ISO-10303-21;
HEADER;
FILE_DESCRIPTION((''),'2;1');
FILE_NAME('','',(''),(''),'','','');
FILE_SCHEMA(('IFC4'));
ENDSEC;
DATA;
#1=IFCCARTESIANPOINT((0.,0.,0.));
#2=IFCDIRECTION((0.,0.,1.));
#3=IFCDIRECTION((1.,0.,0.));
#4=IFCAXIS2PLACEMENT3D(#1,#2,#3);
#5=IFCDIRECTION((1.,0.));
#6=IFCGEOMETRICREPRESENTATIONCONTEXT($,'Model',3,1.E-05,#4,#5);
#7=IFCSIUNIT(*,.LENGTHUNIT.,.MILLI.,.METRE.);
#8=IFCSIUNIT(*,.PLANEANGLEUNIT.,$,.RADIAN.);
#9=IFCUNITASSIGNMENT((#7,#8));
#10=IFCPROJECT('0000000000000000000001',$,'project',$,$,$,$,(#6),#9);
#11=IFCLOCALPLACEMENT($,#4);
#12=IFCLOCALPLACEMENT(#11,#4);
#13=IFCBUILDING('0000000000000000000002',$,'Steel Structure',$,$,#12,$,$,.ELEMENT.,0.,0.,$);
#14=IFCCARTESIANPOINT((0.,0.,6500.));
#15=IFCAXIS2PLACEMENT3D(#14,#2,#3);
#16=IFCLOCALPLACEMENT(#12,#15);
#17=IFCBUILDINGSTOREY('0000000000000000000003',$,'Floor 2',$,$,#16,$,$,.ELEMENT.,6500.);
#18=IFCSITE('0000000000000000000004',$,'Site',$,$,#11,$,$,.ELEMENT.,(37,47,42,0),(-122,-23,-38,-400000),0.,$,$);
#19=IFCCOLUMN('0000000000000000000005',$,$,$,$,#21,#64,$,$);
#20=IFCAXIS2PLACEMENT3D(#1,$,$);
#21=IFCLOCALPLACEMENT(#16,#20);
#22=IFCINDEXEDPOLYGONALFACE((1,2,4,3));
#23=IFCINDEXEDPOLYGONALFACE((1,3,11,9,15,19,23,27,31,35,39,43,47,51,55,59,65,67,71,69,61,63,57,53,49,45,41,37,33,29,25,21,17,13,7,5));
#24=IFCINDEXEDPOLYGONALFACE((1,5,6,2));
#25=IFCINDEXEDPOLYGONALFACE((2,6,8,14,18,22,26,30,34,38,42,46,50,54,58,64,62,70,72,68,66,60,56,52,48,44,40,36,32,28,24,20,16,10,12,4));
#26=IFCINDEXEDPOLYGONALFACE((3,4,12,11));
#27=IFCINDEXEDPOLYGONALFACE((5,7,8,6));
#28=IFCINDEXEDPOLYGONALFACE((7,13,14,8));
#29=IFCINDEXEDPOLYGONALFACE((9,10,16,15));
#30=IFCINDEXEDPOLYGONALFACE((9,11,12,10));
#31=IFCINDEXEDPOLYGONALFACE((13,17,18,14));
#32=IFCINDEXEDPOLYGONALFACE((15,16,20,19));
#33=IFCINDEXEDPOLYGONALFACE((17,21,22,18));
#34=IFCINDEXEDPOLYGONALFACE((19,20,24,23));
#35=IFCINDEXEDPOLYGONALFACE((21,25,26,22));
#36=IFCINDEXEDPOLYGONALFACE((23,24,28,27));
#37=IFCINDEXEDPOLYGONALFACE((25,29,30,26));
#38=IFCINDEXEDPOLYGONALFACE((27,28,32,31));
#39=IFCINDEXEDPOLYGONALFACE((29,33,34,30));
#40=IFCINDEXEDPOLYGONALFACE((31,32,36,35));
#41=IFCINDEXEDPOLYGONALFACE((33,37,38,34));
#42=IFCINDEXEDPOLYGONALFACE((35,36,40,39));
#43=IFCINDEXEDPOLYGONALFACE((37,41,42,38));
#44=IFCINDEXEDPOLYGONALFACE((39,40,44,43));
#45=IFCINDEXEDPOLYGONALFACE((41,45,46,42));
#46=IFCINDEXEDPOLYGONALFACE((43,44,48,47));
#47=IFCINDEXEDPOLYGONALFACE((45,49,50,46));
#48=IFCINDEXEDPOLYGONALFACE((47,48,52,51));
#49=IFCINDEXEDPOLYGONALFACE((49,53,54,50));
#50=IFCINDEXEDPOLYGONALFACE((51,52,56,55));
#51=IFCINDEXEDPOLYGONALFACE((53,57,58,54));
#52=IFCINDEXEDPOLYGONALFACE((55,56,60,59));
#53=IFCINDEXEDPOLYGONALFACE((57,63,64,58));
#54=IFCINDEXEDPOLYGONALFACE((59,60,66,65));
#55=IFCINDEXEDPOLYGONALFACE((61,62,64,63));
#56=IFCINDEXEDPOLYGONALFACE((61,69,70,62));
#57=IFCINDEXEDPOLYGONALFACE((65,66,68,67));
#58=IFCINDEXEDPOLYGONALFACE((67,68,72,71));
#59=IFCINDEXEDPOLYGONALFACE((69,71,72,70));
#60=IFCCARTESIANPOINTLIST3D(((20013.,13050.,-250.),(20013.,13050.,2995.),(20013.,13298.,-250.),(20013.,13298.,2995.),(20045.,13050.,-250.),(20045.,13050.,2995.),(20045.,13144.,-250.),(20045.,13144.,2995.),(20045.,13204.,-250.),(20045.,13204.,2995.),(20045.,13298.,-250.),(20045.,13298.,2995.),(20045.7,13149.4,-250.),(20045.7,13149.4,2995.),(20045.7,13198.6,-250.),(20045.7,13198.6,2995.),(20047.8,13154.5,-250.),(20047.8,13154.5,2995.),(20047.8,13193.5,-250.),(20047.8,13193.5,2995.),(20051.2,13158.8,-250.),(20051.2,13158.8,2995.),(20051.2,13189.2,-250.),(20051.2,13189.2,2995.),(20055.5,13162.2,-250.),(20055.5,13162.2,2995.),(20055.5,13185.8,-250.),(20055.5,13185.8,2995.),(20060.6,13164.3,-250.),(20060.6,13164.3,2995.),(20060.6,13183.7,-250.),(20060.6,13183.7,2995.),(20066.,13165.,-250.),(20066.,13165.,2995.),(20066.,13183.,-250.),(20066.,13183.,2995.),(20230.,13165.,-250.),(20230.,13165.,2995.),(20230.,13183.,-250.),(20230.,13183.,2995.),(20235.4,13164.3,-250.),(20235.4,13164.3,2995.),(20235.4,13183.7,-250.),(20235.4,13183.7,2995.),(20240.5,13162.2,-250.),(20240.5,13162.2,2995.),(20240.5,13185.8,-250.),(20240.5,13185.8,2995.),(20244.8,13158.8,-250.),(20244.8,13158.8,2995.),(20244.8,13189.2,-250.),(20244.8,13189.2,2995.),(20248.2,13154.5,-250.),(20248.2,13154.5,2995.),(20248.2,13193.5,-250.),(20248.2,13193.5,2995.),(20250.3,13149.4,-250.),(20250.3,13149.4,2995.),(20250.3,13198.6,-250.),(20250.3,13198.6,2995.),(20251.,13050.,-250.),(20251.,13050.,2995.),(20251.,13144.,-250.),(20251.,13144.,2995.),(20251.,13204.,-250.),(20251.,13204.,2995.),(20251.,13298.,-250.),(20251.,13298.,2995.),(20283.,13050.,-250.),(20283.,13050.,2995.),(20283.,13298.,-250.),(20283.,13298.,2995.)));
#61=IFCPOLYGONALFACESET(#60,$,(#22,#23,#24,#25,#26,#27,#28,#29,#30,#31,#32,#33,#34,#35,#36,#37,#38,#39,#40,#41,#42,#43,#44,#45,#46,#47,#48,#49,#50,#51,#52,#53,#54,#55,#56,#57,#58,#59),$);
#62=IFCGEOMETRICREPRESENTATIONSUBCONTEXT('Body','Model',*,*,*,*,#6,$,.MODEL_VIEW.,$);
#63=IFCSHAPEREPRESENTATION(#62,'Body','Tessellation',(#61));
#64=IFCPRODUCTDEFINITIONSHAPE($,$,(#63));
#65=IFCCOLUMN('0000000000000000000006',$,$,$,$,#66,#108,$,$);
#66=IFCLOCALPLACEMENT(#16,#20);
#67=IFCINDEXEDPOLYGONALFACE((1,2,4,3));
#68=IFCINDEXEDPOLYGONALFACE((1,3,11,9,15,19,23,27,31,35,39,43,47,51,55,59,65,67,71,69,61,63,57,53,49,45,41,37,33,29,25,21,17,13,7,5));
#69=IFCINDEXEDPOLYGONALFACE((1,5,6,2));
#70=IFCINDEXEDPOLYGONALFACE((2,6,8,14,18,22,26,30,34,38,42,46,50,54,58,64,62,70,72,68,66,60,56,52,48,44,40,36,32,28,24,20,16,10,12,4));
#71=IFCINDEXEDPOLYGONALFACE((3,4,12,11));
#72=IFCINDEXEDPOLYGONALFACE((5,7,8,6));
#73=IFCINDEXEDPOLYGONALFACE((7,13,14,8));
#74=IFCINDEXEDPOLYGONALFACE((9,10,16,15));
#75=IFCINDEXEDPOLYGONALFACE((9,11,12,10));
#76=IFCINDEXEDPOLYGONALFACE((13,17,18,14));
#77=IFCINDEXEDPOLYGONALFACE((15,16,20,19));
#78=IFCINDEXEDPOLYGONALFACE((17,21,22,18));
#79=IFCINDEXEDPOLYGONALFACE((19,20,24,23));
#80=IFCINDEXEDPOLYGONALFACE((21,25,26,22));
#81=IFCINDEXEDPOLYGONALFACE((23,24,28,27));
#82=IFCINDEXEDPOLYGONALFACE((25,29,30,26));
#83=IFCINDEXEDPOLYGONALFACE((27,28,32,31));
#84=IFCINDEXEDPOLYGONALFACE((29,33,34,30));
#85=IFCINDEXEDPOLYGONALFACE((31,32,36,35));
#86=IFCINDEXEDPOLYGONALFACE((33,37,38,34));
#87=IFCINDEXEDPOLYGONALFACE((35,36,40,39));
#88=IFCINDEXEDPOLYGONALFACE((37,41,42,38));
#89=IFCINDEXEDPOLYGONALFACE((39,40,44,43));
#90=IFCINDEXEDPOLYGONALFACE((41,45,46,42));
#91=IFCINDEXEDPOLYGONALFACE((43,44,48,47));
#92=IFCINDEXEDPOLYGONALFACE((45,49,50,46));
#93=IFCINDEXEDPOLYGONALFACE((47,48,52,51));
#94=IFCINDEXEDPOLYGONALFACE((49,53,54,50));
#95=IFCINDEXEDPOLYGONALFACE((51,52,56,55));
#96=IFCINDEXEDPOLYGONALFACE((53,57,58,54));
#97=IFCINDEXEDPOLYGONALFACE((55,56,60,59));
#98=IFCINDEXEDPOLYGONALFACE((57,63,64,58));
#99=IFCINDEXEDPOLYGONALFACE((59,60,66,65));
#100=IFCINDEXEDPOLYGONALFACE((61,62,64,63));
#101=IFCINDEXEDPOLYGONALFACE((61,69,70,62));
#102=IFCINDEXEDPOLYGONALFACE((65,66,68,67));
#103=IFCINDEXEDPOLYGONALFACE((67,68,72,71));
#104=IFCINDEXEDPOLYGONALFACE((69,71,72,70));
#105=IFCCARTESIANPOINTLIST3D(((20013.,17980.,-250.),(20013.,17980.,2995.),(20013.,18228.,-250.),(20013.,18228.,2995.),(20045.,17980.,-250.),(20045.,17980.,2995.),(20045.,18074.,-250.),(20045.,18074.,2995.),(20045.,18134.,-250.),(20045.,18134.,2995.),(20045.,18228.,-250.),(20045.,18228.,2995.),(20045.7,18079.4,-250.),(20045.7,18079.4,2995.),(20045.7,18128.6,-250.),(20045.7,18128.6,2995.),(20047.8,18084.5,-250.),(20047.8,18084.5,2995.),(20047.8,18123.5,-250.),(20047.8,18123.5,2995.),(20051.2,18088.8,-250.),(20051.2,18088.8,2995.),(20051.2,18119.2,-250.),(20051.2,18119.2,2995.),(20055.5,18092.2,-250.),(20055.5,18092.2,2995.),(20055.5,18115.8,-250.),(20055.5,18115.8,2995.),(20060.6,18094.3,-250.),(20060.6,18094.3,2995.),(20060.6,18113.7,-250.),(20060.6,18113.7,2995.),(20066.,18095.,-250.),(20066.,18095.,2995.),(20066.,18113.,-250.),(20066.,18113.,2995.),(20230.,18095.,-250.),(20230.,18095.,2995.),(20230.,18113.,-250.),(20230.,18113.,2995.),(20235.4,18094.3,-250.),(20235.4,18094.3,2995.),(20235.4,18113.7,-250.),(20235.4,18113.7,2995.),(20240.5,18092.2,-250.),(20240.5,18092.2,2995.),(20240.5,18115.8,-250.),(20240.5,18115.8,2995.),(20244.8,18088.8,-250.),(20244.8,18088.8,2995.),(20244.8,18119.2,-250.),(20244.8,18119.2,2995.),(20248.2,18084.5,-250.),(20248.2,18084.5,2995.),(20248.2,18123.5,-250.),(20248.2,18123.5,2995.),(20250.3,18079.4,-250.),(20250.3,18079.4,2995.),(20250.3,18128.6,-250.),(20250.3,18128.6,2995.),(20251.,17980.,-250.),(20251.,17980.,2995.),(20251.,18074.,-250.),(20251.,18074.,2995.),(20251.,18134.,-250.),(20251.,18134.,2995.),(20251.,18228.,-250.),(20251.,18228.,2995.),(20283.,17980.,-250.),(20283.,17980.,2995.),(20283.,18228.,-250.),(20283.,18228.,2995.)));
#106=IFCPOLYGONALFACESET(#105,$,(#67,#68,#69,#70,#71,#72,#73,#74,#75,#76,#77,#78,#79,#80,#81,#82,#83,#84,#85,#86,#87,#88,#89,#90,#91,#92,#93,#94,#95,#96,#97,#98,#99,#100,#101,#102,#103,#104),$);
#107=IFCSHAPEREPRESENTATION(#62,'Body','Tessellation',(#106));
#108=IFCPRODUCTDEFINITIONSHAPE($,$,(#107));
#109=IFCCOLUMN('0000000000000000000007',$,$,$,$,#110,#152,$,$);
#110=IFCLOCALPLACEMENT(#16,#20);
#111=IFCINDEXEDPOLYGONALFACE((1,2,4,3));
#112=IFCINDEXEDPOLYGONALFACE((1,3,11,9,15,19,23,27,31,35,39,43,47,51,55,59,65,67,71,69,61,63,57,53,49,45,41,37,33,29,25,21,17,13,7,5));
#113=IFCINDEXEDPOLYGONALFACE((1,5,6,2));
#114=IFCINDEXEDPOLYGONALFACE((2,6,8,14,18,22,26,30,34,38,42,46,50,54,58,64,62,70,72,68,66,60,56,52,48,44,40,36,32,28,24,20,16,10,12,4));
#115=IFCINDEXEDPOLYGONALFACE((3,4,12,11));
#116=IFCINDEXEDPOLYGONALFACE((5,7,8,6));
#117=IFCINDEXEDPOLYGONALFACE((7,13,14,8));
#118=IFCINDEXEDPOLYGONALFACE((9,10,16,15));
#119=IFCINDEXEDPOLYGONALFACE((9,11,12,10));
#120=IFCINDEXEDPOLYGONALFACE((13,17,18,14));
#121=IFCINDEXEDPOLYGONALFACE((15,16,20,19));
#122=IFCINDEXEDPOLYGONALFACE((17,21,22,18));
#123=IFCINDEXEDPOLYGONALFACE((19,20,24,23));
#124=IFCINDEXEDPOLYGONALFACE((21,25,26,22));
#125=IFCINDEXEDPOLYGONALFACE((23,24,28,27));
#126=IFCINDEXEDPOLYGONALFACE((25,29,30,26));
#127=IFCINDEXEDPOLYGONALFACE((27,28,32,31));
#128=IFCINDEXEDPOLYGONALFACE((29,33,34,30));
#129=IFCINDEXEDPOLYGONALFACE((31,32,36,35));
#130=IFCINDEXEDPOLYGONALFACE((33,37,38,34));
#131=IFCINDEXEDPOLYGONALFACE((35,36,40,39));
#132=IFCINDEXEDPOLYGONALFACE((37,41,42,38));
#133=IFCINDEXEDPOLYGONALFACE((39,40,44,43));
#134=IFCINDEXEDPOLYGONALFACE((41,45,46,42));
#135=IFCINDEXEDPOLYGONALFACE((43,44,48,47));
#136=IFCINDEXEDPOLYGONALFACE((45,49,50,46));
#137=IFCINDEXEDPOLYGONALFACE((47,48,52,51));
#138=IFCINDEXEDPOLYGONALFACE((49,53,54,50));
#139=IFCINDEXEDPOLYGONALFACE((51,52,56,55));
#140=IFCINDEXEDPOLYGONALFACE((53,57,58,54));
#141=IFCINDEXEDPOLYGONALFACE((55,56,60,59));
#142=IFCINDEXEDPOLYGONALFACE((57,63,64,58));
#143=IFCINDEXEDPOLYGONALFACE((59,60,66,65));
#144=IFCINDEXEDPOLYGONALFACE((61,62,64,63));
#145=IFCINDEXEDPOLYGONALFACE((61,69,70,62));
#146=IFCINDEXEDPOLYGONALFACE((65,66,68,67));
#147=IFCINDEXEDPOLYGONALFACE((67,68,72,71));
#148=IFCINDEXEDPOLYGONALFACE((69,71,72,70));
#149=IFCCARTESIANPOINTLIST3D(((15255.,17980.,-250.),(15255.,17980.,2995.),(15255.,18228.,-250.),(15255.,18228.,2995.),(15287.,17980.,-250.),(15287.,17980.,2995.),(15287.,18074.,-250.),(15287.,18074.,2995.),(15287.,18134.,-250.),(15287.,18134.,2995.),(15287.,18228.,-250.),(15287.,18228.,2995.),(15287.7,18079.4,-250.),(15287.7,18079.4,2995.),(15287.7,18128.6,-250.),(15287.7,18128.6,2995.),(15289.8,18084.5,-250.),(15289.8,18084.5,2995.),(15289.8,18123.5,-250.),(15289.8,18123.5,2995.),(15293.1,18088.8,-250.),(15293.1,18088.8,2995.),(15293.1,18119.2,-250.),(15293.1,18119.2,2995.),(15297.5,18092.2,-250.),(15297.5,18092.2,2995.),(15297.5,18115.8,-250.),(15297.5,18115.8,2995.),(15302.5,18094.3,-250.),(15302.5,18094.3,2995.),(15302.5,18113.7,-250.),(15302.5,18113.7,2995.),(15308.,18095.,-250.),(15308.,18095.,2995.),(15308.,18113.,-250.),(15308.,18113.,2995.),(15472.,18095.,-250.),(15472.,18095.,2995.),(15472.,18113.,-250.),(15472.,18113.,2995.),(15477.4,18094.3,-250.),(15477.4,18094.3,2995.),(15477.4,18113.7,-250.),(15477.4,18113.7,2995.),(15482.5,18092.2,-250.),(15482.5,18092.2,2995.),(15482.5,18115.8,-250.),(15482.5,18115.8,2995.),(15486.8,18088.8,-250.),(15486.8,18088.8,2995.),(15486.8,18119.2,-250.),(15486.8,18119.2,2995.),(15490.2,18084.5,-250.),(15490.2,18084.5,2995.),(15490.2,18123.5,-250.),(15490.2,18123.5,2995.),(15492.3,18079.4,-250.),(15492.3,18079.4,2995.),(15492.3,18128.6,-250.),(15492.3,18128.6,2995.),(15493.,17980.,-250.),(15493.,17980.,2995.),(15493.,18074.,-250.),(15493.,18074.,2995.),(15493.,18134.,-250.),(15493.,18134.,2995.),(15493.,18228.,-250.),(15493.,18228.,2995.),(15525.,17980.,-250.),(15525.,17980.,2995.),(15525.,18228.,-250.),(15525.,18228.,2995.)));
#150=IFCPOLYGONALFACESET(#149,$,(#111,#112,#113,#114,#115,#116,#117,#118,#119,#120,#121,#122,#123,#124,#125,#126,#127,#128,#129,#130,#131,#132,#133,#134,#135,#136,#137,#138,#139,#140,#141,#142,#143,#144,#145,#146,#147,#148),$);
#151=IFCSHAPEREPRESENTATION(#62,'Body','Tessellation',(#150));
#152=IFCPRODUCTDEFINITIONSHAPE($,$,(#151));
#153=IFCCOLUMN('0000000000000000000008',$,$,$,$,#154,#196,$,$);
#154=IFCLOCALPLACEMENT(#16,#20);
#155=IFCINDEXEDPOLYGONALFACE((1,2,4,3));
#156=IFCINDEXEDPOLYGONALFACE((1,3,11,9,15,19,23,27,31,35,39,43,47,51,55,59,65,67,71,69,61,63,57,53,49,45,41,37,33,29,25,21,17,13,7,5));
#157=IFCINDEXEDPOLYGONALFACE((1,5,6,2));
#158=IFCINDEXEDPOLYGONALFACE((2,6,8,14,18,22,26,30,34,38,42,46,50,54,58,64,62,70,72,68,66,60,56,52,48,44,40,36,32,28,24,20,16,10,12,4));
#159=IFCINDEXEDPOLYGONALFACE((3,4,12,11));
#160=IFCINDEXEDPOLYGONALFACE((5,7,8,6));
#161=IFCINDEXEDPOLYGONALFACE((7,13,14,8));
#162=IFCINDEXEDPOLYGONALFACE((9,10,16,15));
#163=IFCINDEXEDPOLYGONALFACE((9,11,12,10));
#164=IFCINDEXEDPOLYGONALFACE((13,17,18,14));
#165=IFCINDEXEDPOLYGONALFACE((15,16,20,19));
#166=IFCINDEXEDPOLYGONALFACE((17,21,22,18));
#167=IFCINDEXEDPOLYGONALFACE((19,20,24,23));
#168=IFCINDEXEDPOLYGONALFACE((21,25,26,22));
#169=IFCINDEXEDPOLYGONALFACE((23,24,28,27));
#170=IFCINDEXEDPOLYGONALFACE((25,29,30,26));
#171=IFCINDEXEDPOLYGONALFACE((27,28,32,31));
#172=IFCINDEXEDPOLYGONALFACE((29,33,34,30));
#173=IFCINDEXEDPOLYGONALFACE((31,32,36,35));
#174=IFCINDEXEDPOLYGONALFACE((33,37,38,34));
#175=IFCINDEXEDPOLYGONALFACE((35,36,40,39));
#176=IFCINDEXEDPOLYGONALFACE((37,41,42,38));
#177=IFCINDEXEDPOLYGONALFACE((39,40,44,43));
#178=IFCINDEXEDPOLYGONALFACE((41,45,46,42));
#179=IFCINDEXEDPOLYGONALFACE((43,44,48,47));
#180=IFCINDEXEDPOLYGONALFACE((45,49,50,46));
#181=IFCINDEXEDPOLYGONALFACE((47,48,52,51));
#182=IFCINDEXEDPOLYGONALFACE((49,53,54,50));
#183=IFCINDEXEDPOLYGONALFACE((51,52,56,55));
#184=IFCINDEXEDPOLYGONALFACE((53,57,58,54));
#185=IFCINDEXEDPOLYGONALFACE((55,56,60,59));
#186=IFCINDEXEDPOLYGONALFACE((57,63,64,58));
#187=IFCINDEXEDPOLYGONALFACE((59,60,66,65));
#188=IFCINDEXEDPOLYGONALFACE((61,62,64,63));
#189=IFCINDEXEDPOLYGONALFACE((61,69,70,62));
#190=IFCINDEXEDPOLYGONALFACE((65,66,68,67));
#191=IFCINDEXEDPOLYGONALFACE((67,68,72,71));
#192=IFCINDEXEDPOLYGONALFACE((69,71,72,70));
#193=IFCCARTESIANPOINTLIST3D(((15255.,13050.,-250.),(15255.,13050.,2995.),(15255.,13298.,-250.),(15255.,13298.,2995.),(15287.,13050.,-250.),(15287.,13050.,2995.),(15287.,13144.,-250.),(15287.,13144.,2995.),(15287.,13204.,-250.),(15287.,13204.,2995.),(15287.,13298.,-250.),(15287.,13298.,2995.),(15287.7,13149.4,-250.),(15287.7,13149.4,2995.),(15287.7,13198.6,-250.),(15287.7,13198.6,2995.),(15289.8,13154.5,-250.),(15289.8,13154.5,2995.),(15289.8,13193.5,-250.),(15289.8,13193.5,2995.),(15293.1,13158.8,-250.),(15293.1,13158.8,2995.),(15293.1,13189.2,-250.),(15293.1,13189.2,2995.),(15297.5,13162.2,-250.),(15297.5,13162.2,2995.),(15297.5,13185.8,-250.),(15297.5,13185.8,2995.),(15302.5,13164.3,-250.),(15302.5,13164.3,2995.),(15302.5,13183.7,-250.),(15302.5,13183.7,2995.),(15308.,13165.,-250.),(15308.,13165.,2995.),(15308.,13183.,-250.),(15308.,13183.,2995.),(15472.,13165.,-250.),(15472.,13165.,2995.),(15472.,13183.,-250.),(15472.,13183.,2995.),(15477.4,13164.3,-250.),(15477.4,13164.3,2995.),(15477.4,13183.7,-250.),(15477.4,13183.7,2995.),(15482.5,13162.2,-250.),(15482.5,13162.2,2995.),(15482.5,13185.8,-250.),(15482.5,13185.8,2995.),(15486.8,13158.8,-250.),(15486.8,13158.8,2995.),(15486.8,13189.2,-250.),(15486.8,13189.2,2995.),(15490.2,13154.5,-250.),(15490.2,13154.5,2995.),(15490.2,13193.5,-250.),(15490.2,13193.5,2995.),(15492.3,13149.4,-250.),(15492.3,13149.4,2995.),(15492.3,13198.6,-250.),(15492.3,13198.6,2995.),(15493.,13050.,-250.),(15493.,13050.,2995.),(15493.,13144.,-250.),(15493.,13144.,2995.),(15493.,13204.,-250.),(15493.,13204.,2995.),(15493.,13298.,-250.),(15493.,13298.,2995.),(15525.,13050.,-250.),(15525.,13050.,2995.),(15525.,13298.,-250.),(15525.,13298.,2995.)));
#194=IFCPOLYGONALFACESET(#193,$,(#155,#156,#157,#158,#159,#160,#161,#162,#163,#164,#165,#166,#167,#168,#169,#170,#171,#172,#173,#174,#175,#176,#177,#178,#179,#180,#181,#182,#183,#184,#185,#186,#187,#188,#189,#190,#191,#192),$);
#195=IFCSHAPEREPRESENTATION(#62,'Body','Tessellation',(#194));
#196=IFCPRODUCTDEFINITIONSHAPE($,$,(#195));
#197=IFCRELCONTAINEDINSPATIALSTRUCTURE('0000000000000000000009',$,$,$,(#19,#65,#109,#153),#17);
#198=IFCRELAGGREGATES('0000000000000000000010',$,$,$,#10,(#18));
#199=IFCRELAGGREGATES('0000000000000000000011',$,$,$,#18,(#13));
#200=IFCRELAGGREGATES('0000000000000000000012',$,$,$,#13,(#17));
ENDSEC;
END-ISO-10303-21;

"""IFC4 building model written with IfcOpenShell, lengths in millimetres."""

from ifc_helpers import new_model, si_unit, direction, frame, origin_with_axes, origin_2d_with_axis, place, context, subcontext, project, spatial, i_section, extrude, element, save


model = new_model("IFC4")

# Units and contexts
model_context = context("Model", 3, precision=1e-05, world=origin_with_axes(), true_north=direction((1.0, 0.0)))
body_context = subcontext(model_context, "Body", "Model", "MODEL_VIEW")
ifc_project = project(units=[si_unit("LENGTHUNIT", "METRE", prefix="MILLI"), si_unit("PLANEANGLEUNIT", "RADIAN")], contexts=[model_context])

# Site, building, storey
site_placement = place(None, origin_with_axes())
site = spatial("IfcSite", under=ifc_project, at=site_placement, Name="Site", CompositionType="ELEMENT", RefLatitude=(37, 47, 42, 0), RefLongitude=(-122, -23, -38, -400000), RefElevation=0.0)
building_placement = place(site_placement, origin_with_axes())
building = spatial("IfcBuilding", under=site, at=building_placement, Name="Steel Structure", CompositionType="ELEMENT", ElevationOfRefHeight=0.0, ElevationOfTerrain=0.0)
storey_placement = place(building_placement, frame((0.0, 0.0, 6500.0), z_axis=(0.0, 0.0, 1.0), x_axis=(1.0, 0.0, 0.0)))
storey = spatial("IfcBuildingStorey", under=building, at=storey_placement, Name="Floor 2", CompositionType="ELEMENT", Elevation=6500.0)

# Columns
for number, where, z_axis, x_axis in (
    (1, (20148.0, 13174.0, -250.0), (0.0, 0.0, 1.0), (0.0, -1.0, 0.0)),
    (2, (20148.0, 18104.0, -250.0), (0.0, 0.0, 1.0), (0.0, -1.0, 0.0)),
    (3, (15390.0, 18104.0, -250.0), (0.0, 0.0, 1.0), (0.0, -1.0, 0.0)),
    (4, (15390.0, 13174.0, -250.0), (0.0, 0.0, 1.0), (0.0, -1.0, 0.0)),
):
    element("IfcColumn", number, at=place(storey_placement, frame(where, z_axis=z_axis, x_axis=x_axis)), inside=storey, context=body_context, shape_type="SweptSolid", body=[
        extrude(i_section(OverallWidth=248.0, OverallDepth=270.0, WebThickness=18.0, FlangeThickness=32.0, FilletRadius=21.0, at=origin_2d_with_axis()), origin_with_axes(), (0.0, 0.0, 1.0), 3245.0),
    ])

save(model, "model.ifc")
